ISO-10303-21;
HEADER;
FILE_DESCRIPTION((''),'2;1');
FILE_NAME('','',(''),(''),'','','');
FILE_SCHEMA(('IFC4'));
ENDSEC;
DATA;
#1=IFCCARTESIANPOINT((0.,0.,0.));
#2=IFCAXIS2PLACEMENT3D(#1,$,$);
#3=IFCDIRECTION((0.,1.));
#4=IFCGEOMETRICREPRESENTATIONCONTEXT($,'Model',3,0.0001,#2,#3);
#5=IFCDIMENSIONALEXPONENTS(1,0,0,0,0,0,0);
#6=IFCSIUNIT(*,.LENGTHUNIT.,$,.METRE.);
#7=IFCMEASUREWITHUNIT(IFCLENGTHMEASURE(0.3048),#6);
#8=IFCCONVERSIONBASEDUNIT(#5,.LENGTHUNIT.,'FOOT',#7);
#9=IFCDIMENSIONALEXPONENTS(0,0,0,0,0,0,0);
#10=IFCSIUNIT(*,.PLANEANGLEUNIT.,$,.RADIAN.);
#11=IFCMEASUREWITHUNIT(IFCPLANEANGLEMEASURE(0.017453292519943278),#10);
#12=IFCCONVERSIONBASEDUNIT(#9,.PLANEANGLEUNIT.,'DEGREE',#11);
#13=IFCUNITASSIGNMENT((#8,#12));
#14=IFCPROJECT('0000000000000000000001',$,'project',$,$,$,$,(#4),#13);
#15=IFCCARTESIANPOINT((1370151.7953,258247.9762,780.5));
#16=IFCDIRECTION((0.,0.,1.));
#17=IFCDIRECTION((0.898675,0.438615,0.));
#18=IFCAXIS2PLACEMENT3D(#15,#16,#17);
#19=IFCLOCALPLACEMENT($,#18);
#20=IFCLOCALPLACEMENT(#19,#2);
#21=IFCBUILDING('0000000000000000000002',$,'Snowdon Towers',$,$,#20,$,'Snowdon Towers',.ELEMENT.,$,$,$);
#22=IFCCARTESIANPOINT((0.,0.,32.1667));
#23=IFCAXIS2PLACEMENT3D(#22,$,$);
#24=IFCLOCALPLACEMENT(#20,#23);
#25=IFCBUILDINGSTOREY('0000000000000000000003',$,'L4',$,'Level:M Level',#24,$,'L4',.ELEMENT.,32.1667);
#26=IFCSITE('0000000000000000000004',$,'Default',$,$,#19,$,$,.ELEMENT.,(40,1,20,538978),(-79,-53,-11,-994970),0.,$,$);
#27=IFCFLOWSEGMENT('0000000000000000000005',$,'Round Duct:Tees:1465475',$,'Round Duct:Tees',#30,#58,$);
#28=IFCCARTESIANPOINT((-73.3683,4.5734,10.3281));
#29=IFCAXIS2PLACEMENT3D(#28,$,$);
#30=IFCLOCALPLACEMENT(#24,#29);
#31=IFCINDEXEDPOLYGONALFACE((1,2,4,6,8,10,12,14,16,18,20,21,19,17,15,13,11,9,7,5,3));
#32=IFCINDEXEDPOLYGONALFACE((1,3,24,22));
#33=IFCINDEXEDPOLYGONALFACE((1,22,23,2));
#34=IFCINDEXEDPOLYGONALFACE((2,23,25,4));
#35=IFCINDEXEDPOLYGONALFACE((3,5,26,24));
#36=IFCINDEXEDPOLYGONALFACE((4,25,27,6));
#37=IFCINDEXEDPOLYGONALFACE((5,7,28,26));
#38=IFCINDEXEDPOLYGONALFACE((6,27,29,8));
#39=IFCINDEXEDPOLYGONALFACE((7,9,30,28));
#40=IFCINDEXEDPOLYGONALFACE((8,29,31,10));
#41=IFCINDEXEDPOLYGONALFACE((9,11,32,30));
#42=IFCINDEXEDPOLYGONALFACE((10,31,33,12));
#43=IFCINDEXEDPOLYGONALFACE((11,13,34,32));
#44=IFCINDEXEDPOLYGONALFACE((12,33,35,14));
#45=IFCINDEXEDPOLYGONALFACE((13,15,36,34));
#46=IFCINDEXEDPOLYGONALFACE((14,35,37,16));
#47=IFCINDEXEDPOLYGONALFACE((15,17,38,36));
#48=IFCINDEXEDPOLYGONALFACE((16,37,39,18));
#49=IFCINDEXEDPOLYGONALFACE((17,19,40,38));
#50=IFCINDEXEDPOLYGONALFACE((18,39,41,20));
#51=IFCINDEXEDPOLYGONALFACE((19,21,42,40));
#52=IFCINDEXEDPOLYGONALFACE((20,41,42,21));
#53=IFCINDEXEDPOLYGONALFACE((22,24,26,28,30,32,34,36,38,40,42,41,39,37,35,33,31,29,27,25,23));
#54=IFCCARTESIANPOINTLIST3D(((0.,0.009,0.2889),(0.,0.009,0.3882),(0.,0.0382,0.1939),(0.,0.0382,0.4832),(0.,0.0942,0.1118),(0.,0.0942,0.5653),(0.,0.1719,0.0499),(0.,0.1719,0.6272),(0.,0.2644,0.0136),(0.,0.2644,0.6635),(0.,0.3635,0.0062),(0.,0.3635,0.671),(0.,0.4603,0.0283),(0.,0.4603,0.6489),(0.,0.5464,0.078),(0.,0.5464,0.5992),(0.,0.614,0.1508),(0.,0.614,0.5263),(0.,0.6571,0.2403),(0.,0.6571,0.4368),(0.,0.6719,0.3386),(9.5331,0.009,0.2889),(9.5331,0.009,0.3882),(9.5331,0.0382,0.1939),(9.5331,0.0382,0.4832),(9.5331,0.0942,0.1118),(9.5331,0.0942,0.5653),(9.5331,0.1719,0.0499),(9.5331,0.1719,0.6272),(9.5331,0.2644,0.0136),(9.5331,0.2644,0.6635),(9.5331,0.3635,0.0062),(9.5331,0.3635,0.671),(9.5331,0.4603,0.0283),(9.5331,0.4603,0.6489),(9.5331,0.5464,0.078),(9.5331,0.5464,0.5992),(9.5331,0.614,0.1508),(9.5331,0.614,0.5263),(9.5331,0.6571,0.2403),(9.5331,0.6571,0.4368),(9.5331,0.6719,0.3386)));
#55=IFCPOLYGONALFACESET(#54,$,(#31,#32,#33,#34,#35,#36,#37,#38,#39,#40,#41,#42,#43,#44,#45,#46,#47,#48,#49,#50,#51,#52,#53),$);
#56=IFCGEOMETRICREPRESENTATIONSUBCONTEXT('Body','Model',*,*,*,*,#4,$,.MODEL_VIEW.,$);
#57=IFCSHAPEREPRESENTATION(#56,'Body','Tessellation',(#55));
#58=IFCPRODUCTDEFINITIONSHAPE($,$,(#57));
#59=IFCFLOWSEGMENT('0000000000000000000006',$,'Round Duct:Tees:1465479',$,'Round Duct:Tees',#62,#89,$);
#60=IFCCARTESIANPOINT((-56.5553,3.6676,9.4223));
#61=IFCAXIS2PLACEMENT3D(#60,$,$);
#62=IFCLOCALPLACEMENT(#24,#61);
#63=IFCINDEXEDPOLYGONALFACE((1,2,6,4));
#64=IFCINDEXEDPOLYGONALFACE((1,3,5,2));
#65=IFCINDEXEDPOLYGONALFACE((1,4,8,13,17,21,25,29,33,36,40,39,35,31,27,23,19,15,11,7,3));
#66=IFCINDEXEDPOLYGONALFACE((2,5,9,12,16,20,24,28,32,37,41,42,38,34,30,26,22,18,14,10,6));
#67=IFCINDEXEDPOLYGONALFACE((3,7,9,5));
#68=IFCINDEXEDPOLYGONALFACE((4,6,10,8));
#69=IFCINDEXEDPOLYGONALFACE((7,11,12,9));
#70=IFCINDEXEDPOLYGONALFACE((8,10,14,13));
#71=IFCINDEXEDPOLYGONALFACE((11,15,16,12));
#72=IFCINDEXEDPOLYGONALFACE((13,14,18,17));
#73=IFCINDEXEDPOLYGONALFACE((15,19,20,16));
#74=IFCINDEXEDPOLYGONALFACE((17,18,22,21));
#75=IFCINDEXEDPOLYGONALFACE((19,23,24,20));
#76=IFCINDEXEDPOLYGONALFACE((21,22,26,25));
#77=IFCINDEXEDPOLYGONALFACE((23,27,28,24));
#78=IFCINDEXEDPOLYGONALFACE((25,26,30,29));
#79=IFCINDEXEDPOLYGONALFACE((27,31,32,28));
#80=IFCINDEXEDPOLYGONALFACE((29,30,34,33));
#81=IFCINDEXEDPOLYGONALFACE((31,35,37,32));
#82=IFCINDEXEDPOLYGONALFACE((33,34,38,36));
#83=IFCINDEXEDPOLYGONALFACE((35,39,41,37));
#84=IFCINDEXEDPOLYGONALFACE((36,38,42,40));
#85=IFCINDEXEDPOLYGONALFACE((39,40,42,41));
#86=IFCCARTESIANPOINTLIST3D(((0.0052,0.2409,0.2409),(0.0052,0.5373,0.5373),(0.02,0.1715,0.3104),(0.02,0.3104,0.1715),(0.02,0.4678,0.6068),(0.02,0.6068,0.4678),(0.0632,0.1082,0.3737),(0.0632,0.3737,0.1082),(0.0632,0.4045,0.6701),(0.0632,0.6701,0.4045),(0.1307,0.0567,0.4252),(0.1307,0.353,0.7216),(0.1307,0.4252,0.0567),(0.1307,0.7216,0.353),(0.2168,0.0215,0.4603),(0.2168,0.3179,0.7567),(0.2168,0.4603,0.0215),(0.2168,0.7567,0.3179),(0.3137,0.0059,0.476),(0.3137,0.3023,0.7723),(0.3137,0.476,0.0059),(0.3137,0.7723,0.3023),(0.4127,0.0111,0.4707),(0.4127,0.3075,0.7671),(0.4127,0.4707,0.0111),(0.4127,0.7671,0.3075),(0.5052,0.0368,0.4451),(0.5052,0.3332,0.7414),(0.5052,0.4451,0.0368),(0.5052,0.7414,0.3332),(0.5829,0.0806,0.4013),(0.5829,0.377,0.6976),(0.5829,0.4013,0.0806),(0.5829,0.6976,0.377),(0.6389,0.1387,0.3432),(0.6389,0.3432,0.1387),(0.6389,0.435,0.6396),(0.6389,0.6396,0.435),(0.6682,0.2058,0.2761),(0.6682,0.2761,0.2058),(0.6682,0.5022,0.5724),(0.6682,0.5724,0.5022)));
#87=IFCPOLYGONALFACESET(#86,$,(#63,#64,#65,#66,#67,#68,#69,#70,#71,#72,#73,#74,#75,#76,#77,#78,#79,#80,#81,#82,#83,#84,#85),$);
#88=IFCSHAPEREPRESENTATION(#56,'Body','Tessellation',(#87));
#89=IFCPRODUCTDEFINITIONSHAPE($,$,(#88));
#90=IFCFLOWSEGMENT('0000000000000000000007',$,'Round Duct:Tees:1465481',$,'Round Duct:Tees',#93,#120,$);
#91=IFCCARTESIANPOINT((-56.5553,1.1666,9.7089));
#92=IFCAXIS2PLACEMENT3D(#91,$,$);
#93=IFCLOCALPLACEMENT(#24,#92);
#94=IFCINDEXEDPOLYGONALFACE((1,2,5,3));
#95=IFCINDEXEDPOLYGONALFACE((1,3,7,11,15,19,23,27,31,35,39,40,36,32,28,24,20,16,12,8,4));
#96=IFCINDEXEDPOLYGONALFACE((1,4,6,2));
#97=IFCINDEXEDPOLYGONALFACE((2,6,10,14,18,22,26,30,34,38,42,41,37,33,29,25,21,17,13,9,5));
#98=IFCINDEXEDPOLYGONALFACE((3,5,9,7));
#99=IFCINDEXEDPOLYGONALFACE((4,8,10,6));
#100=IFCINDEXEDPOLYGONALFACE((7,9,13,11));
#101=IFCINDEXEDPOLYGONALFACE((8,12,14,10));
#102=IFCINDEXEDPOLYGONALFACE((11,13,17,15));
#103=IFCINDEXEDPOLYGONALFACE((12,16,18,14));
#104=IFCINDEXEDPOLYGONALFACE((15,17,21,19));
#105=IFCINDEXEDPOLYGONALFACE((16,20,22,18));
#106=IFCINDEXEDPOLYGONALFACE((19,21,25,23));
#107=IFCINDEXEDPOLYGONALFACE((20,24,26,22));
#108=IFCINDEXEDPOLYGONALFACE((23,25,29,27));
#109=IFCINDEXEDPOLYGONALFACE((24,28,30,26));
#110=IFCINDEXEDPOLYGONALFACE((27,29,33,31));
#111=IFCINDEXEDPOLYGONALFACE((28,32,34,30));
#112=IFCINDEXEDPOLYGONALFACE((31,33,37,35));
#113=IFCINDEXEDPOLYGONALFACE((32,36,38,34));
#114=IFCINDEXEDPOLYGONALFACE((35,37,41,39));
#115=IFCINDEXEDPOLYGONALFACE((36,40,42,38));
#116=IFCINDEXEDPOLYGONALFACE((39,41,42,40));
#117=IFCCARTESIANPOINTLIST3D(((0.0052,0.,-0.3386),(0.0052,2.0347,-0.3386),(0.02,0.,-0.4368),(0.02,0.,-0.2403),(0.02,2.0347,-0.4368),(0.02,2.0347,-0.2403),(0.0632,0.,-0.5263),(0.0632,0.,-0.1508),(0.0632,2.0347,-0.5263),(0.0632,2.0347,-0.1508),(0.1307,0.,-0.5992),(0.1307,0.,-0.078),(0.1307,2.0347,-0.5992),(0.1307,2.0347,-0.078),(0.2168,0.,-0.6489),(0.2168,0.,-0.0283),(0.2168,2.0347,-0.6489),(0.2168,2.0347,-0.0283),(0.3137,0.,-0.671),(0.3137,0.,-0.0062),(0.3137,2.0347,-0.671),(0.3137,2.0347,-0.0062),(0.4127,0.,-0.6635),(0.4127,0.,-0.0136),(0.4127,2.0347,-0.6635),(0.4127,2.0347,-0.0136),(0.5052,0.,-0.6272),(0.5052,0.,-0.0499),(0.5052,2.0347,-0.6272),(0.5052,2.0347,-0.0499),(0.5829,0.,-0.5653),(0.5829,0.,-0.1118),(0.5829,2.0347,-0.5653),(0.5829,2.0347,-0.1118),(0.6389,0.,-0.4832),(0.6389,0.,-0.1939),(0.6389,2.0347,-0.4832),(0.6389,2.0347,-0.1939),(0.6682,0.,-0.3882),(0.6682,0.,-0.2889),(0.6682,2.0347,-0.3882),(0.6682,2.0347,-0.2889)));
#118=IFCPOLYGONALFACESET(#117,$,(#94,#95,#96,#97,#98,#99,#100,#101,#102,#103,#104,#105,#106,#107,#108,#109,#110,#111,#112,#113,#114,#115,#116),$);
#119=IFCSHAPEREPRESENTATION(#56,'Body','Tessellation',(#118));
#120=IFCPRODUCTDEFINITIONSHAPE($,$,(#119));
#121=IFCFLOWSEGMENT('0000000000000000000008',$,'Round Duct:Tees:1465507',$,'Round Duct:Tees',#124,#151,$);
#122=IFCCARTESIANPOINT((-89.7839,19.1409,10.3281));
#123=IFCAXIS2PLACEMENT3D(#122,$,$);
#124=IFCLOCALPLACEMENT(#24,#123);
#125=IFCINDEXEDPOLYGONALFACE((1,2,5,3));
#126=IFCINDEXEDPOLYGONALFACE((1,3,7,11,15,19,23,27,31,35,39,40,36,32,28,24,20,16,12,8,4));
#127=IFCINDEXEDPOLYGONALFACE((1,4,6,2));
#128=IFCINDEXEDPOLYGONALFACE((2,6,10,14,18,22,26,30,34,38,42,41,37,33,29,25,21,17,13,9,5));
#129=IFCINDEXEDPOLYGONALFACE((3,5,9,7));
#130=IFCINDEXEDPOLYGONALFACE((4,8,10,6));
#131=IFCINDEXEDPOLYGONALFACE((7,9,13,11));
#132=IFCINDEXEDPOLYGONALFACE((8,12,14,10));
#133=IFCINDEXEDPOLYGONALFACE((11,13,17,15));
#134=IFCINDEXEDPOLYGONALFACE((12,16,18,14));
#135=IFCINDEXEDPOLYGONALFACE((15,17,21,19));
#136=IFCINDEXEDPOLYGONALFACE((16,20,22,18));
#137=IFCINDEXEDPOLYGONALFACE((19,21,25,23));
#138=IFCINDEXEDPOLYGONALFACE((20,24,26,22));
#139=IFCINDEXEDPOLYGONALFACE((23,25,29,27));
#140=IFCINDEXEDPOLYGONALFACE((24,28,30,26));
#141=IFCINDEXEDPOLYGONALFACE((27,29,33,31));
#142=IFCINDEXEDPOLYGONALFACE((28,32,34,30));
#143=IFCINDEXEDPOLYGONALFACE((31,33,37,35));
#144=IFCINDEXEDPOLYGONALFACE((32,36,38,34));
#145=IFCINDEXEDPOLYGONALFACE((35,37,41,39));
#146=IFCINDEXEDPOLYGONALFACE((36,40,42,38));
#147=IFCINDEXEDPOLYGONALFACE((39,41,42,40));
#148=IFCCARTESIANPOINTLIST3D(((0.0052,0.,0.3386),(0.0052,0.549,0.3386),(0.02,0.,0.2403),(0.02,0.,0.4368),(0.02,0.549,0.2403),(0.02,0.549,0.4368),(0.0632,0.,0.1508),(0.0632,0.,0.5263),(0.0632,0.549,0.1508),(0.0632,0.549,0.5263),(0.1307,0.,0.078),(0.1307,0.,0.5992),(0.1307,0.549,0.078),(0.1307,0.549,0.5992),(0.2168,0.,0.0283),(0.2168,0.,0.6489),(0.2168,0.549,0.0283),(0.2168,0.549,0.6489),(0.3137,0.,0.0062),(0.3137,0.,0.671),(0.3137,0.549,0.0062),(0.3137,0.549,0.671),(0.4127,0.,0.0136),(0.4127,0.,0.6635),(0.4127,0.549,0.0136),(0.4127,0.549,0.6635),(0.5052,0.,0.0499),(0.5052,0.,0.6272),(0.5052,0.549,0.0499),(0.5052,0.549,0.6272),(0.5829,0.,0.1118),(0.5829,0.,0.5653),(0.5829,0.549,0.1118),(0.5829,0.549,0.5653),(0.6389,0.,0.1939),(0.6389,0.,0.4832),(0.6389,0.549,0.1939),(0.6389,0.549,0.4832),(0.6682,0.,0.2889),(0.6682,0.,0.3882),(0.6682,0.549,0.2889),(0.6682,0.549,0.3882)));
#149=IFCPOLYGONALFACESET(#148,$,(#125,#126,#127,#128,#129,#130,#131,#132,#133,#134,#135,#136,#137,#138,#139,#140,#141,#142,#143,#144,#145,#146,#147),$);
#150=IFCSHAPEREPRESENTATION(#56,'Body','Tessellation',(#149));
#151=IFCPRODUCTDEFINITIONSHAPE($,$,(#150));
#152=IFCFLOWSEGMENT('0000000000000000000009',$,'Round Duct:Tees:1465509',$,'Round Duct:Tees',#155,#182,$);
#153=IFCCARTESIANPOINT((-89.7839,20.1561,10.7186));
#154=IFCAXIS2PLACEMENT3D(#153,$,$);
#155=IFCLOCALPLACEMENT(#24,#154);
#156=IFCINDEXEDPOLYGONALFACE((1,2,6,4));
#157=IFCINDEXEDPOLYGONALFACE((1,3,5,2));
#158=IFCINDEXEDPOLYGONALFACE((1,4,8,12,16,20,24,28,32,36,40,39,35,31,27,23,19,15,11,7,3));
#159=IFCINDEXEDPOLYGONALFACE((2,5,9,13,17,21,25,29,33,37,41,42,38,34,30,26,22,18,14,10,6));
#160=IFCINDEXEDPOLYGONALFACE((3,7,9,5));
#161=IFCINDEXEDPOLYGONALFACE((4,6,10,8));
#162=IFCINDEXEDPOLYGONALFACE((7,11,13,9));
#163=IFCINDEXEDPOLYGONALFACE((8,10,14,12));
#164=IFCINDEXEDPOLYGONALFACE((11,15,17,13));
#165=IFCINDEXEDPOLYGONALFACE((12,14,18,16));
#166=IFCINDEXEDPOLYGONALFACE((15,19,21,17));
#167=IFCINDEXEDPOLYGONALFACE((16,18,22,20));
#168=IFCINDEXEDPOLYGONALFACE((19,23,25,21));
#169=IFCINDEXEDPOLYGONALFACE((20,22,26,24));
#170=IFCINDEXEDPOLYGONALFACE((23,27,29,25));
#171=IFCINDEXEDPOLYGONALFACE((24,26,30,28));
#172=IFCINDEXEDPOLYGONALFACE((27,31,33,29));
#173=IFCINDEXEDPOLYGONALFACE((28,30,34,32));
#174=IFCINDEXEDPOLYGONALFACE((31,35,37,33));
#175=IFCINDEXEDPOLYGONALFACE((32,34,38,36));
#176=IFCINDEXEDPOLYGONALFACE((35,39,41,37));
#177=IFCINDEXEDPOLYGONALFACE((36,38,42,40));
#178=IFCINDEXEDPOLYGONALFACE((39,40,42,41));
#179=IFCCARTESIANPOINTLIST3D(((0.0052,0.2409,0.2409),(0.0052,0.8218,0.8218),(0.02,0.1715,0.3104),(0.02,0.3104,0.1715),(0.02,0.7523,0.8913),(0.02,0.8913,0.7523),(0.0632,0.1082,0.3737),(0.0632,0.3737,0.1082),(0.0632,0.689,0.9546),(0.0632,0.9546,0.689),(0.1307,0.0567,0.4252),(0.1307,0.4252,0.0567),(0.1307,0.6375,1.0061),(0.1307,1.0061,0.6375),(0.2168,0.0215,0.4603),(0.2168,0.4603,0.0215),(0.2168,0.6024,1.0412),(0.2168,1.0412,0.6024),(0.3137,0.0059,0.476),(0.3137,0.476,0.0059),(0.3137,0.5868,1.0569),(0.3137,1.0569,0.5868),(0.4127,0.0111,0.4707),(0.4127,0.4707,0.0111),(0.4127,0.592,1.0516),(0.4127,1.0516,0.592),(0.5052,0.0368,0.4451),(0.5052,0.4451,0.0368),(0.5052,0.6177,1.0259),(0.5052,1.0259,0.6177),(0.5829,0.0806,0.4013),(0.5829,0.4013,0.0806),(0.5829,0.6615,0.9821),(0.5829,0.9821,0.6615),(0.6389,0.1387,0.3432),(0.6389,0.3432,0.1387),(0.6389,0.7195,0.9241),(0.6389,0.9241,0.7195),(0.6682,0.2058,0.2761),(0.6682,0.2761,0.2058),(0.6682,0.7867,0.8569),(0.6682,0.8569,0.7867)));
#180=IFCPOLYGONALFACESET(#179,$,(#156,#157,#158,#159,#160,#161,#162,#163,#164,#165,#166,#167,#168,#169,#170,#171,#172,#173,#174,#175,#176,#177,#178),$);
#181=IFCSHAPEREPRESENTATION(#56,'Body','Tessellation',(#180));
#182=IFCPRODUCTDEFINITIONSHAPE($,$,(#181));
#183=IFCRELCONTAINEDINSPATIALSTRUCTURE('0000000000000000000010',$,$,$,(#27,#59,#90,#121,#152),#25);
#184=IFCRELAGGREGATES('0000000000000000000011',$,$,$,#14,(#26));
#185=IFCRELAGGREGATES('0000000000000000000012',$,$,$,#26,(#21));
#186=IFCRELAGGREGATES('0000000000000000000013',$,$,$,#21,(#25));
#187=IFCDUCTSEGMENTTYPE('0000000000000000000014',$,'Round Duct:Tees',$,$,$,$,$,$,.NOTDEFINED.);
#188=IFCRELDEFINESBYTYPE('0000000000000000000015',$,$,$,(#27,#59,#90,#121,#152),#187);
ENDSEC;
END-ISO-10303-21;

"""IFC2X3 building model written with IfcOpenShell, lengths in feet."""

from ifc_helpers import new_model, entity, si_unit, converted_unit, direction, frame, frame_2d, origin, place, context, subcontext, project, spatial, circle, extrude, type_object, element, save


model = new_model("IFC2X3")

# Units and contexts
model_context = context("Model", 3, precision=0.0001, world=origin(), true_north=direction((0.0, 1.0)))
body_context = subcontext(model_context, "Body", "Model", "MODEL_VIEW")
ifc_project = project(units=[converted_unit("LENGTHUNIT", "FOOT", entity("IfcLengthMeasure", 0.3048), si_unit("LENGTHUNIT", "METRE"), dimensions=[1, 0, 0, 0, 0, 0, 0]), converted_unit("PLANEANGLEUNIT", "DEGREE", entity("IfcPlaneAngleMeasure", 0.017453292519943278), si_unit("PLANEANGLEUNIT", "RADIAN"), dimensions=[0, 0, 0, 0, 0, 0, 0])], contexts=[model_context])

# Site, building, storey
site_placement = place(None, frame((1370151.7953, 258247.9762, 780.5), z_axis=(0.0, 0.0, 1.0), x_axis=(0.898675, 0.438615, 0.0)))
site = spatial("IfcSite", under=ifc_project, at=site_placement, Name="Default", CompositionType="ELEMENT", RefLatitude=(40, 1, 20, 538978), RefLongitude=(-79, -53, -11, -994970), RefElevation=0.0)
building_placement = place(site_placement, origin())
building = spatial("IfcBuilding", under=site, at=building_placement, Name="Snowdon Towers", LongName="Snowdon Towers", CompositionType="ELEMENT")
storey_placement = place(building_placement, frame((0.0, 0.0, 32.1667)))
storey = spatial("IfcBuildingStorey", under=building, at=storey_placement, Name="L4", ObjectType="Level:M Level", LongName="L4", CompositionType="ELEMENT", Elevation=32.1667)

# Flow segments
duct_segment_type = type_object("IfcDuctSegmentType", Name="Round Duct:Tees", PredefinedType="NOTDEFINED")
flow_segment_1_placement = place(storey_placement, frame((-73.3683, 4.5734, 10.3281)))
element("IfcFlowSegment", 1, at=flow_segment_1_placement, inside=storey, type_object=duct_segment_type, Name="Round Duct:Tees:1465475", ObjectType="Round Duct:Tees", context=body_context, shape_type="SweptSolid", body=[
    extrude(circle(Radius=0.3333, at=frame_2d((0.0, 0.0), x_axis=(1.0, 0.0))), frame((0.0, 0.3386, 0.3386), z_axis=(1.0, 0.0, 0.0), x_axis=(0.0, 1.0, 0.0)), (0.0, 0.0, 1.0), 9.5331),
])
flow_segment_2_placement = place(storey_placement, frame((-56.5553, 3.6676, 9.4223)))
element("IfcFlowSegment", 2, at=flow_segment_2_placement, inside=storey, type_object=duct_segment_type, Name="Round Duct:Tees:1465479", ObjectType="Round Duct:Tees", context=body_context, shape_type="SweptSolid", body=[
    extrude(circle(Radius=0.3333, at=frame_2d((0.0, 0.0), x_axis=(1.0, 0.0))), frame((0.3386, 0.2409, 0.2409), z_axis=(0.0, 0.707107, 0.707107), x_axis=(-1.0, 0.0, 0.0)), (0.0, 0.0, 1.0), 0.4191),
])
flow_segment_3_placement = place(storey_placement, frame((-56.5553, 1.1666, 9.7089)))
element("IfcFlowSegment", 3, at=flow_segment_3_placement, inside=storey, type_object=duct_segment_type, Name="Round Duct:Tees:1465481", ObjectType="Round Duct:Tees", context=body_context, shape_type="SweptSolid", body=[
    extrude(circle(Radius=0.3333, at=frame_2d((0.0, 0.0), x_axis=(1.0, 0.0))), frame((0.3386, 0.0, -0.3386), z_axis=(0.0, 1.0, 0.0), x_axis=(-1.0, 0.0, 0.0)), (0.0, 0.0, 1.0), 2.0347),
])
flow_segment_4_placement = place(storey_placement, frame((-89.7839, 19.1409, 10.3281)))
element("IfcFlowSegment", 4, at=flow_segment_4_placement, inside=storey, type_object=duct_segment_type, Name="Round Duct:Tees:1465507", ObjectType="Round Duct:Tees", context=body_context, shape_type="SweptSolid", body=[
    extrude(circle(Radius=0.3333, at=frame_2d((0.0, 0.0), x_axis=(1.0, 0.0))), frame((0.3386, 0.0, 0.3386), z_axis=(0.0, 1.0, 0.0), x_axis=(-1.0, 0.0, 0.0)), (0.0, 0.0, 1.0), 0.549),
])
flow_segment_5_placement = place(storey_placement, frame((-89.7839, 20.1561, 10.7186)))
element("IfcFlowSegment", 5, at=flow_segment_5_placement, inside=storey, type_object=duct_segment_type, Name="Round Duct:Tees:1465509", ObjectType="Round Duct:Tees", context=body_context, shape_type="SweptSolid", body=[
    extrude(circle(Radius=0.3333, at=frame_2d((0.0, 0.0), x_axis=(1.0, 0.0))), frame((0.3386, 0.2409, 0.2409), z_axis=(0.0, 0.707107, 0.707107), x_axis=(-1.0, 0.0, 0.0)), (0.0, 0.0, 1.0), 0.8215),
])

save(model, "model.ifc")
